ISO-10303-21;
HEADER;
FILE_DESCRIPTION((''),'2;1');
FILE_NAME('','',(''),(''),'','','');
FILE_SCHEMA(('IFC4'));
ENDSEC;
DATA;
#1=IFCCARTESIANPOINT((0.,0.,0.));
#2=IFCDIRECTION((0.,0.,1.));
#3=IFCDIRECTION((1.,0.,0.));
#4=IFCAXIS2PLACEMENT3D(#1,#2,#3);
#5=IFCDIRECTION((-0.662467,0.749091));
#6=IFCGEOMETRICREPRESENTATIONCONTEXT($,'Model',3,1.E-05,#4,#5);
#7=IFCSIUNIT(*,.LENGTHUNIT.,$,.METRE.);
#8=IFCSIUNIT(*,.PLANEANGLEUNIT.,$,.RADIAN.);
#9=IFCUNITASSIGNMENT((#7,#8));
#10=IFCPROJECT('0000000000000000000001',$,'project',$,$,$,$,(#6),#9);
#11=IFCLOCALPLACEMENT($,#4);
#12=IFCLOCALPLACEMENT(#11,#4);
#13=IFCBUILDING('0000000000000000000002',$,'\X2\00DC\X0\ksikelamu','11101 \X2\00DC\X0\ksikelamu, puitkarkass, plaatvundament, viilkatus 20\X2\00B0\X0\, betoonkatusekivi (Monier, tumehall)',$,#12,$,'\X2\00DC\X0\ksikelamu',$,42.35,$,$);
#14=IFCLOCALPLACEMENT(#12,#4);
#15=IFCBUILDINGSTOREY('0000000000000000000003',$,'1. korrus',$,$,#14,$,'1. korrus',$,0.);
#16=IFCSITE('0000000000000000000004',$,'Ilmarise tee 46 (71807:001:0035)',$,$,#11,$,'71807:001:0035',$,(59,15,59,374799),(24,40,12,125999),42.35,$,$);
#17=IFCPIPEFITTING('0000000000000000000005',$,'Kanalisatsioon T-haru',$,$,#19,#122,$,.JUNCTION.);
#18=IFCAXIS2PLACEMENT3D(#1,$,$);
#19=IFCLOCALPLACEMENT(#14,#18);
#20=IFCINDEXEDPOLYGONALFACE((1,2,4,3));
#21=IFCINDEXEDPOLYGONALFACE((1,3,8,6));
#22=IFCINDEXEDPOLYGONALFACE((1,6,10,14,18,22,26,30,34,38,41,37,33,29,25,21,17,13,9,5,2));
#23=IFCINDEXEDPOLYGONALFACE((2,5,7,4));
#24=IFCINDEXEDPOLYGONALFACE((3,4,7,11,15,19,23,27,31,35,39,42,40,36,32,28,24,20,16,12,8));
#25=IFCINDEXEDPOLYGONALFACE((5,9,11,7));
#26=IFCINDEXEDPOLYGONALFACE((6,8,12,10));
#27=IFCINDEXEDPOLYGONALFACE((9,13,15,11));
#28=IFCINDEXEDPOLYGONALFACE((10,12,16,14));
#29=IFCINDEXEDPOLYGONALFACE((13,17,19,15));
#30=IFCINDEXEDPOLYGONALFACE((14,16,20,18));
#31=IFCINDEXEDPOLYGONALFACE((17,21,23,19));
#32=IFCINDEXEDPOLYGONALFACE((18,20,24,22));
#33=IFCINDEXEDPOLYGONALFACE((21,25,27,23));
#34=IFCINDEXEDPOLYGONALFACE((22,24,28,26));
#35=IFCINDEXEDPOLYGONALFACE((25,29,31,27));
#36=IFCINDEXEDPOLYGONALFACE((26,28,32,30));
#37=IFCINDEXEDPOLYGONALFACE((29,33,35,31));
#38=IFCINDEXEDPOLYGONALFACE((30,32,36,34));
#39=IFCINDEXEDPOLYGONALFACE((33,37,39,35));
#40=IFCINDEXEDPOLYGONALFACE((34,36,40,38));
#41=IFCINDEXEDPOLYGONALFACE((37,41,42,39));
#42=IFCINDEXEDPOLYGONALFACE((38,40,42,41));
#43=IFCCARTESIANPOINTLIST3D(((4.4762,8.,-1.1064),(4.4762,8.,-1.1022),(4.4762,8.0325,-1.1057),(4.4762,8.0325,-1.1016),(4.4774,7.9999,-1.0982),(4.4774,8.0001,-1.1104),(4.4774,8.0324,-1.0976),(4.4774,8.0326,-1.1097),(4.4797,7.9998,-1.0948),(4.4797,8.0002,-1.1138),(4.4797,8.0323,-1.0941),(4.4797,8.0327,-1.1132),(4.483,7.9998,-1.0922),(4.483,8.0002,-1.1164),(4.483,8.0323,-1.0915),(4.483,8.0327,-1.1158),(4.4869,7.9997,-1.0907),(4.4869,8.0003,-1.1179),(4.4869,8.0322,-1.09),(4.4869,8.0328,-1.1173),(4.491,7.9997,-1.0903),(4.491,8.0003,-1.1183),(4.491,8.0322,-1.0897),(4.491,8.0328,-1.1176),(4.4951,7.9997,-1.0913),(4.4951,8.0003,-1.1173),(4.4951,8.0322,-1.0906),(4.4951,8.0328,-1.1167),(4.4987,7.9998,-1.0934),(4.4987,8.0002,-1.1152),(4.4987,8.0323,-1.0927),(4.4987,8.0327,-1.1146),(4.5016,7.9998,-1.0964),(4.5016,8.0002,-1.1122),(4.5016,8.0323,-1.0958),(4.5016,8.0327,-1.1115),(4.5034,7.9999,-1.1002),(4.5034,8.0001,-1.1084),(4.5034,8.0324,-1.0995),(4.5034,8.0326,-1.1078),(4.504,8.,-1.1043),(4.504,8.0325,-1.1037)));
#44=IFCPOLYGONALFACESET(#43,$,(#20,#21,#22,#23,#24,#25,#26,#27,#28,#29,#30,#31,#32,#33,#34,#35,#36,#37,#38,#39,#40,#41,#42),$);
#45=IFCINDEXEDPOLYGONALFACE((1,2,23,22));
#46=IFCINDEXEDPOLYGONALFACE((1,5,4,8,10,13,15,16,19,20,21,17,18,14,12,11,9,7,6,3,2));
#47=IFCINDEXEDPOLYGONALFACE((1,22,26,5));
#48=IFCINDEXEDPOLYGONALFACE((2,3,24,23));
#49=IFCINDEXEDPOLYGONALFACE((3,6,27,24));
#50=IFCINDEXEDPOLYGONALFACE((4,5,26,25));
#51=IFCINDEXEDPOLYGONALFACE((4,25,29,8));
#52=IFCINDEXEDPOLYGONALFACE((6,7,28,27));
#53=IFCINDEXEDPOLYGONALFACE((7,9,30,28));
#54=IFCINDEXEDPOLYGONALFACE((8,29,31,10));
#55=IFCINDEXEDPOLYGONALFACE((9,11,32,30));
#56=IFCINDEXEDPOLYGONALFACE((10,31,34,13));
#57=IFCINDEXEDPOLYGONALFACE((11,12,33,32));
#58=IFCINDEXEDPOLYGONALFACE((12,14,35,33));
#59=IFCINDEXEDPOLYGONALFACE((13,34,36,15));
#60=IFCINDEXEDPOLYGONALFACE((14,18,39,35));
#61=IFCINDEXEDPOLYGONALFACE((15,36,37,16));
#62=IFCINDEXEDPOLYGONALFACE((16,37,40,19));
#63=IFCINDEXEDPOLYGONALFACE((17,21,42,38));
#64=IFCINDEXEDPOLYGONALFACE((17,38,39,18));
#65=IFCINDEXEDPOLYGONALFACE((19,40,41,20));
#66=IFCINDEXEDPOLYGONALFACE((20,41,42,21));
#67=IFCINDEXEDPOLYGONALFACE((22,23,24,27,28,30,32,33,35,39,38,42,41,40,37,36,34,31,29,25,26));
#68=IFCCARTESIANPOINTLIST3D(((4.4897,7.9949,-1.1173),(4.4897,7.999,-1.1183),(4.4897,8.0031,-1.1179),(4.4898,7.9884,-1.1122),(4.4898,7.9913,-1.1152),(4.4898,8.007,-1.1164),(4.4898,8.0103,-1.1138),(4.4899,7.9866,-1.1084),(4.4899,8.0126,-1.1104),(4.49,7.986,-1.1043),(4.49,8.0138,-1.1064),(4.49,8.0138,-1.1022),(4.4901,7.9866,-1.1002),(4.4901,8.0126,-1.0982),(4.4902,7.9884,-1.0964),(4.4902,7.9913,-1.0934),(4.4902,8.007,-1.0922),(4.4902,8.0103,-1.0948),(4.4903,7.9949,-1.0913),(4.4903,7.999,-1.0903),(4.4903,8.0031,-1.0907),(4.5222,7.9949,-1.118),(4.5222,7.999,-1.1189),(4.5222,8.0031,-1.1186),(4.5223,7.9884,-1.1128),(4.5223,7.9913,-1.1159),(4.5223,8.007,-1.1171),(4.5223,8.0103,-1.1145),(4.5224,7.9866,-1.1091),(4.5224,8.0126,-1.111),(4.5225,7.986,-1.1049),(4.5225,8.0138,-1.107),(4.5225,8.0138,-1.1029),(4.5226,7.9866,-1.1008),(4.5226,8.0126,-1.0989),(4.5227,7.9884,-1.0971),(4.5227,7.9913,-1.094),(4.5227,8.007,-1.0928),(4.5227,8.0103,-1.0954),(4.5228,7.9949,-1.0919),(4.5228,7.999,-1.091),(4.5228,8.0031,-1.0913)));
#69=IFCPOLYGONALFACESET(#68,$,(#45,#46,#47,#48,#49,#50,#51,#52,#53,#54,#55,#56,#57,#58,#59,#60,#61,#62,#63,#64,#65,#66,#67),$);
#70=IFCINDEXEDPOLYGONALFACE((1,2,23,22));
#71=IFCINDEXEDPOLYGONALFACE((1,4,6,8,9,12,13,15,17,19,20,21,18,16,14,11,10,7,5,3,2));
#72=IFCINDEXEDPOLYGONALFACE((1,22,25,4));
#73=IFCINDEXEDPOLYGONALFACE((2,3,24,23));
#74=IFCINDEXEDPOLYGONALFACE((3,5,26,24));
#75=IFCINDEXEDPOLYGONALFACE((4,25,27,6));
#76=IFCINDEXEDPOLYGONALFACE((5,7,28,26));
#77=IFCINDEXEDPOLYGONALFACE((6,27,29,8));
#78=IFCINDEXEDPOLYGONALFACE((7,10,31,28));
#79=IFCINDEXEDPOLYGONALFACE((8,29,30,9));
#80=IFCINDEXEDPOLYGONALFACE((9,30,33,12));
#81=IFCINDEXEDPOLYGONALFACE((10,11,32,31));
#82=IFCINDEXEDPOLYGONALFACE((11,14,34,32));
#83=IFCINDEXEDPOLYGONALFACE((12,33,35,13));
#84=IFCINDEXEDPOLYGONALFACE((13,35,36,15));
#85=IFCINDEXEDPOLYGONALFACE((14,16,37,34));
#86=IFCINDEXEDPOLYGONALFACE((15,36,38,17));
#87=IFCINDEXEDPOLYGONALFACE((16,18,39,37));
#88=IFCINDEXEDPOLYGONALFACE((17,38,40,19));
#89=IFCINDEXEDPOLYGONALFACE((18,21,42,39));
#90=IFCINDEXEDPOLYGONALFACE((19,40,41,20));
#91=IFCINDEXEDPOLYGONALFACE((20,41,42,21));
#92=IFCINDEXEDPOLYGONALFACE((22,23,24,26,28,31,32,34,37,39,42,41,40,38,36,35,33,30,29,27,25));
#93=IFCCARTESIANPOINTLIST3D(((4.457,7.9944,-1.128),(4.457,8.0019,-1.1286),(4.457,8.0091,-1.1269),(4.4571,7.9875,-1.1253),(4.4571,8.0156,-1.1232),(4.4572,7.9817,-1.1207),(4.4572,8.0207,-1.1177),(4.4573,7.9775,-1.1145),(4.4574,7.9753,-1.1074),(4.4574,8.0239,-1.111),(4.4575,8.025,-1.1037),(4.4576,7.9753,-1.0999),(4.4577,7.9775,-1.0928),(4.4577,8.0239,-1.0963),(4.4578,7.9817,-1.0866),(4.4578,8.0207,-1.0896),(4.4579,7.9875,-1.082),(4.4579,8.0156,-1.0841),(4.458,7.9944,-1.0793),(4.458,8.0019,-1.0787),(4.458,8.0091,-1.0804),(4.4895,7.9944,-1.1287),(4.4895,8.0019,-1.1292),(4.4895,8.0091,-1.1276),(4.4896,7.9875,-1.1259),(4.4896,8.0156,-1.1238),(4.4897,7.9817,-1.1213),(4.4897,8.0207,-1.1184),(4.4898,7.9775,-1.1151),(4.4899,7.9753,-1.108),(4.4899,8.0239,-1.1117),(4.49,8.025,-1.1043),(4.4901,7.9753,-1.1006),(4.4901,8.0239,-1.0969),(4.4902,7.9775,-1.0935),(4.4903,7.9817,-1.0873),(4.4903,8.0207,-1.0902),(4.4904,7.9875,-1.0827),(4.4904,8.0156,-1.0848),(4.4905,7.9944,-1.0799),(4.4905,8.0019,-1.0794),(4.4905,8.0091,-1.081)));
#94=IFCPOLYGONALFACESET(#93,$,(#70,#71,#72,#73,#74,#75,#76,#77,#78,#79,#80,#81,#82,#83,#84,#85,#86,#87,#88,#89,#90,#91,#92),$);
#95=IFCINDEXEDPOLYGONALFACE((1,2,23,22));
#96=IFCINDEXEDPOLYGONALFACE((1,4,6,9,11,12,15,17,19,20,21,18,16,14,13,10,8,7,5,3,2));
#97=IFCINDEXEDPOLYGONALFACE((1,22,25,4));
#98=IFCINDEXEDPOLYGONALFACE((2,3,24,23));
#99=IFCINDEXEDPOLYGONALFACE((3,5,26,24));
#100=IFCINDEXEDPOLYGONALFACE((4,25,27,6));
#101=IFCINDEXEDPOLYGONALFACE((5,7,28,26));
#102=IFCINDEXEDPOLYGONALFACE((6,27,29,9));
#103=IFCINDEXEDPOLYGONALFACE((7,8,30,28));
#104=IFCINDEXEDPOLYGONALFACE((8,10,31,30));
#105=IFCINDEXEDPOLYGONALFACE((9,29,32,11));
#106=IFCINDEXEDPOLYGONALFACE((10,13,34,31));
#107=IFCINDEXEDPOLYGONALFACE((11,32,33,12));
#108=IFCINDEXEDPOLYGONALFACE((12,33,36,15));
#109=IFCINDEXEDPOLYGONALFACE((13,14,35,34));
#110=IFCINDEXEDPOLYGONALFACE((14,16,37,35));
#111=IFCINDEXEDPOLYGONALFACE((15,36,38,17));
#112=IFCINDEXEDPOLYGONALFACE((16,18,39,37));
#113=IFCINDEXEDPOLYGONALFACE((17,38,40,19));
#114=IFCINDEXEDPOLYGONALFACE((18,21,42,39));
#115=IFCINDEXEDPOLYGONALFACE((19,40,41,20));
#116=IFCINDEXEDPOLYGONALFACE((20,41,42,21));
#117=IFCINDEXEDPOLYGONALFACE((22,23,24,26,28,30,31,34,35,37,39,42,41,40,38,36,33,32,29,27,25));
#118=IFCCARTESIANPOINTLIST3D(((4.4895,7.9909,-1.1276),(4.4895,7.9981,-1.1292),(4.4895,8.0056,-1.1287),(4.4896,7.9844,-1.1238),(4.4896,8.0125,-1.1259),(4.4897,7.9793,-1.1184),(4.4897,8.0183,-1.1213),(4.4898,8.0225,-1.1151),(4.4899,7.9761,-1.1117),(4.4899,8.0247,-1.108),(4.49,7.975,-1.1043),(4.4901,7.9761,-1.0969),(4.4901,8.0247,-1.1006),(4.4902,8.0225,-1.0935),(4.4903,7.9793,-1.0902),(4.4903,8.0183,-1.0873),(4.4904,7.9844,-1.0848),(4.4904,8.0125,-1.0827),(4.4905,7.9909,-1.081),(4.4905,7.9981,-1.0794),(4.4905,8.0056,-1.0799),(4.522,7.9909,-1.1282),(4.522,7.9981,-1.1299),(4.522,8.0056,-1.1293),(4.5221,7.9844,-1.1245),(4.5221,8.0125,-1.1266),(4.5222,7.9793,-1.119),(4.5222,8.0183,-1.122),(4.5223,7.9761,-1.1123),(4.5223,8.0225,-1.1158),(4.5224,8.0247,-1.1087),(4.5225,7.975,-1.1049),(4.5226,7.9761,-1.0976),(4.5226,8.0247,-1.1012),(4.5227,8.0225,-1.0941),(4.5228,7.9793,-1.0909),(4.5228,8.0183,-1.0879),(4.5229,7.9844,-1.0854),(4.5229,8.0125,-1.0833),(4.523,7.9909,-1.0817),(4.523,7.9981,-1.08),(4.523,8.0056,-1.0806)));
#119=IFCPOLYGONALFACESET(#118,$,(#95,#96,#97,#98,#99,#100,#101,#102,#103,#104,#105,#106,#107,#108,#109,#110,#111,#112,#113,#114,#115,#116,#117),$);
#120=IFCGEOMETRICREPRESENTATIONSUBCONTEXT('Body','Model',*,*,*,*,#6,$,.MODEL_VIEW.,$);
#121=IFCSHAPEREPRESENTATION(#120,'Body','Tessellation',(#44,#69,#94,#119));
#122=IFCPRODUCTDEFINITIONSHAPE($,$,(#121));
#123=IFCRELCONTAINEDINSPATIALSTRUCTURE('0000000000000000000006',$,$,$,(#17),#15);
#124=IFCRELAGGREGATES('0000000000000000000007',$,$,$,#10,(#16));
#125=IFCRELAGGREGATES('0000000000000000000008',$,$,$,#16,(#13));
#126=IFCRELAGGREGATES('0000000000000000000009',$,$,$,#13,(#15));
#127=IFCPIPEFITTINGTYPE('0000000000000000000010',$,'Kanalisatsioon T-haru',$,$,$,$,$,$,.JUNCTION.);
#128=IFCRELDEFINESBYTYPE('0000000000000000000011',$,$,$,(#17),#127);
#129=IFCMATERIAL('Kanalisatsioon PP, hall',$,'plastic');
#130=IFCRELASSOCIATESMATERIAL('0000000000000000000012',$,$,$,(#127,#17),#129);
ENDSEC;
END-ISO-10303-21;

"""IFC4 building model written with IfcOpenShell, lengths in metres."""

from ifc_helpers import new_model, si_unit, direction, frame, origin_with_axes, place, context, subcontext, project, spatial, circle, extrude, material, type_object, element, save


model = new_model("IFC4")

# Units and contexts
model_context = context("Model", 3, precision=1e-05, world=origin_with_axes(), true_north=direction((-0.662467, 0.749091)))
body_context = subcontext(model_context, "Body", "Model", "MODEL_VIEW")
ifc_project = project(units=[si_unit("LENGTHUNIT", "METRE"), si_unit("PLANEANGLEUNIT", "RADIAN")], contexts=[model_context])

# Site, building, storey
site_placement = place(None, origin_with_axes())
site = spatial("IfcSite", under=ifc_project, at=site_placement, Name="Ilmarise tee 46 (71807:001:0035)", LongName="71807:001:0035", RefLatitude=(59, 15, 59, 374799), RefLongitude=(24, 40, 12, 125999), RefElevation=42.35)
building_placement = place(site_placement, origin_with_axes())
building = spatial("IfcBuilding", under=site, at=building_placement, Name="Üksikelamu", Description="11101 Üksikelamu, puitkarkass, plaatvundament, viilkatus 20°, betoonkatusekivi (Monier, tumehall)", LongName="Üksikelamu", ElevationOfRefHeight=42.35)
storey_placement = place(building_placement, origin_with_axes())
storey = spatial("IfcBuildingStorey", under=building, at=storey_placement, Name="1. korrus", LongName="1. korrus", Elevation=0.0)

# Pipe fitting
ifc_material_1 = material(Name="Kanalisatsioon PP, hall", Category="plastic")
pipe_fitting_type_1 = type_object("IfcPipeFittingType", Name="Kanalisatsioon T-haru", PredefinedType="JUNCTION", material=ifc_material_1)
pipe_fitting_1_placement = place(storey_placement, frame((4.49, 8.0, -1.1043), z_axis=(0.0, 0.0, 1.0), x_axis=(1.0, 0.0, 0.0)))
element("IfcPipeFitting", 1, at=pipe_fitting_1_placement, inside=storey, type_object=pipe_fitting_type_1, material=ifc_material_1, Name="Kanalisatsioon T-haru", PredefinedType="JUNCTION", context=body_context, shape_type="SweptSolid", body=[
    extrude(circle(Radius=0.014), frame((0.0, 0.0, 0.0), z_axis=(0.0, 0.9998, 0.019996), x_axis=(1.0, 0.0, 0.0)), (0.0, 0.0, 1.0), 0.0325),
    extrude(circle(Radius=0.014), frame((0.0, 0.0, 0.0), z_axis=(0.9998, 0.0, -0.019996), x_axis=(0.0, -1.0, 0.0)), (0.0, 0.0, 1.0), 0.0325),
    extrude(circle(Radius=0.025), frame((0.0, 0.0, 0.0), z_axis=(-0.9998, 0.0, 0.019996), x_axis=(0.0, 1.0, 0.0)), (0.0, 0.0, 1.0), 0.0325),
    extrude(circle(Radius=0.025), frame((0.0, 0.0, 0.0), z_axis=(0.9998, 0.0, -0.019996), x_axis=(0.0, -1.0, 0.0)), (0.0, 0.0, 1.0), 0.0325),
])

save(model, "model.ifc")
